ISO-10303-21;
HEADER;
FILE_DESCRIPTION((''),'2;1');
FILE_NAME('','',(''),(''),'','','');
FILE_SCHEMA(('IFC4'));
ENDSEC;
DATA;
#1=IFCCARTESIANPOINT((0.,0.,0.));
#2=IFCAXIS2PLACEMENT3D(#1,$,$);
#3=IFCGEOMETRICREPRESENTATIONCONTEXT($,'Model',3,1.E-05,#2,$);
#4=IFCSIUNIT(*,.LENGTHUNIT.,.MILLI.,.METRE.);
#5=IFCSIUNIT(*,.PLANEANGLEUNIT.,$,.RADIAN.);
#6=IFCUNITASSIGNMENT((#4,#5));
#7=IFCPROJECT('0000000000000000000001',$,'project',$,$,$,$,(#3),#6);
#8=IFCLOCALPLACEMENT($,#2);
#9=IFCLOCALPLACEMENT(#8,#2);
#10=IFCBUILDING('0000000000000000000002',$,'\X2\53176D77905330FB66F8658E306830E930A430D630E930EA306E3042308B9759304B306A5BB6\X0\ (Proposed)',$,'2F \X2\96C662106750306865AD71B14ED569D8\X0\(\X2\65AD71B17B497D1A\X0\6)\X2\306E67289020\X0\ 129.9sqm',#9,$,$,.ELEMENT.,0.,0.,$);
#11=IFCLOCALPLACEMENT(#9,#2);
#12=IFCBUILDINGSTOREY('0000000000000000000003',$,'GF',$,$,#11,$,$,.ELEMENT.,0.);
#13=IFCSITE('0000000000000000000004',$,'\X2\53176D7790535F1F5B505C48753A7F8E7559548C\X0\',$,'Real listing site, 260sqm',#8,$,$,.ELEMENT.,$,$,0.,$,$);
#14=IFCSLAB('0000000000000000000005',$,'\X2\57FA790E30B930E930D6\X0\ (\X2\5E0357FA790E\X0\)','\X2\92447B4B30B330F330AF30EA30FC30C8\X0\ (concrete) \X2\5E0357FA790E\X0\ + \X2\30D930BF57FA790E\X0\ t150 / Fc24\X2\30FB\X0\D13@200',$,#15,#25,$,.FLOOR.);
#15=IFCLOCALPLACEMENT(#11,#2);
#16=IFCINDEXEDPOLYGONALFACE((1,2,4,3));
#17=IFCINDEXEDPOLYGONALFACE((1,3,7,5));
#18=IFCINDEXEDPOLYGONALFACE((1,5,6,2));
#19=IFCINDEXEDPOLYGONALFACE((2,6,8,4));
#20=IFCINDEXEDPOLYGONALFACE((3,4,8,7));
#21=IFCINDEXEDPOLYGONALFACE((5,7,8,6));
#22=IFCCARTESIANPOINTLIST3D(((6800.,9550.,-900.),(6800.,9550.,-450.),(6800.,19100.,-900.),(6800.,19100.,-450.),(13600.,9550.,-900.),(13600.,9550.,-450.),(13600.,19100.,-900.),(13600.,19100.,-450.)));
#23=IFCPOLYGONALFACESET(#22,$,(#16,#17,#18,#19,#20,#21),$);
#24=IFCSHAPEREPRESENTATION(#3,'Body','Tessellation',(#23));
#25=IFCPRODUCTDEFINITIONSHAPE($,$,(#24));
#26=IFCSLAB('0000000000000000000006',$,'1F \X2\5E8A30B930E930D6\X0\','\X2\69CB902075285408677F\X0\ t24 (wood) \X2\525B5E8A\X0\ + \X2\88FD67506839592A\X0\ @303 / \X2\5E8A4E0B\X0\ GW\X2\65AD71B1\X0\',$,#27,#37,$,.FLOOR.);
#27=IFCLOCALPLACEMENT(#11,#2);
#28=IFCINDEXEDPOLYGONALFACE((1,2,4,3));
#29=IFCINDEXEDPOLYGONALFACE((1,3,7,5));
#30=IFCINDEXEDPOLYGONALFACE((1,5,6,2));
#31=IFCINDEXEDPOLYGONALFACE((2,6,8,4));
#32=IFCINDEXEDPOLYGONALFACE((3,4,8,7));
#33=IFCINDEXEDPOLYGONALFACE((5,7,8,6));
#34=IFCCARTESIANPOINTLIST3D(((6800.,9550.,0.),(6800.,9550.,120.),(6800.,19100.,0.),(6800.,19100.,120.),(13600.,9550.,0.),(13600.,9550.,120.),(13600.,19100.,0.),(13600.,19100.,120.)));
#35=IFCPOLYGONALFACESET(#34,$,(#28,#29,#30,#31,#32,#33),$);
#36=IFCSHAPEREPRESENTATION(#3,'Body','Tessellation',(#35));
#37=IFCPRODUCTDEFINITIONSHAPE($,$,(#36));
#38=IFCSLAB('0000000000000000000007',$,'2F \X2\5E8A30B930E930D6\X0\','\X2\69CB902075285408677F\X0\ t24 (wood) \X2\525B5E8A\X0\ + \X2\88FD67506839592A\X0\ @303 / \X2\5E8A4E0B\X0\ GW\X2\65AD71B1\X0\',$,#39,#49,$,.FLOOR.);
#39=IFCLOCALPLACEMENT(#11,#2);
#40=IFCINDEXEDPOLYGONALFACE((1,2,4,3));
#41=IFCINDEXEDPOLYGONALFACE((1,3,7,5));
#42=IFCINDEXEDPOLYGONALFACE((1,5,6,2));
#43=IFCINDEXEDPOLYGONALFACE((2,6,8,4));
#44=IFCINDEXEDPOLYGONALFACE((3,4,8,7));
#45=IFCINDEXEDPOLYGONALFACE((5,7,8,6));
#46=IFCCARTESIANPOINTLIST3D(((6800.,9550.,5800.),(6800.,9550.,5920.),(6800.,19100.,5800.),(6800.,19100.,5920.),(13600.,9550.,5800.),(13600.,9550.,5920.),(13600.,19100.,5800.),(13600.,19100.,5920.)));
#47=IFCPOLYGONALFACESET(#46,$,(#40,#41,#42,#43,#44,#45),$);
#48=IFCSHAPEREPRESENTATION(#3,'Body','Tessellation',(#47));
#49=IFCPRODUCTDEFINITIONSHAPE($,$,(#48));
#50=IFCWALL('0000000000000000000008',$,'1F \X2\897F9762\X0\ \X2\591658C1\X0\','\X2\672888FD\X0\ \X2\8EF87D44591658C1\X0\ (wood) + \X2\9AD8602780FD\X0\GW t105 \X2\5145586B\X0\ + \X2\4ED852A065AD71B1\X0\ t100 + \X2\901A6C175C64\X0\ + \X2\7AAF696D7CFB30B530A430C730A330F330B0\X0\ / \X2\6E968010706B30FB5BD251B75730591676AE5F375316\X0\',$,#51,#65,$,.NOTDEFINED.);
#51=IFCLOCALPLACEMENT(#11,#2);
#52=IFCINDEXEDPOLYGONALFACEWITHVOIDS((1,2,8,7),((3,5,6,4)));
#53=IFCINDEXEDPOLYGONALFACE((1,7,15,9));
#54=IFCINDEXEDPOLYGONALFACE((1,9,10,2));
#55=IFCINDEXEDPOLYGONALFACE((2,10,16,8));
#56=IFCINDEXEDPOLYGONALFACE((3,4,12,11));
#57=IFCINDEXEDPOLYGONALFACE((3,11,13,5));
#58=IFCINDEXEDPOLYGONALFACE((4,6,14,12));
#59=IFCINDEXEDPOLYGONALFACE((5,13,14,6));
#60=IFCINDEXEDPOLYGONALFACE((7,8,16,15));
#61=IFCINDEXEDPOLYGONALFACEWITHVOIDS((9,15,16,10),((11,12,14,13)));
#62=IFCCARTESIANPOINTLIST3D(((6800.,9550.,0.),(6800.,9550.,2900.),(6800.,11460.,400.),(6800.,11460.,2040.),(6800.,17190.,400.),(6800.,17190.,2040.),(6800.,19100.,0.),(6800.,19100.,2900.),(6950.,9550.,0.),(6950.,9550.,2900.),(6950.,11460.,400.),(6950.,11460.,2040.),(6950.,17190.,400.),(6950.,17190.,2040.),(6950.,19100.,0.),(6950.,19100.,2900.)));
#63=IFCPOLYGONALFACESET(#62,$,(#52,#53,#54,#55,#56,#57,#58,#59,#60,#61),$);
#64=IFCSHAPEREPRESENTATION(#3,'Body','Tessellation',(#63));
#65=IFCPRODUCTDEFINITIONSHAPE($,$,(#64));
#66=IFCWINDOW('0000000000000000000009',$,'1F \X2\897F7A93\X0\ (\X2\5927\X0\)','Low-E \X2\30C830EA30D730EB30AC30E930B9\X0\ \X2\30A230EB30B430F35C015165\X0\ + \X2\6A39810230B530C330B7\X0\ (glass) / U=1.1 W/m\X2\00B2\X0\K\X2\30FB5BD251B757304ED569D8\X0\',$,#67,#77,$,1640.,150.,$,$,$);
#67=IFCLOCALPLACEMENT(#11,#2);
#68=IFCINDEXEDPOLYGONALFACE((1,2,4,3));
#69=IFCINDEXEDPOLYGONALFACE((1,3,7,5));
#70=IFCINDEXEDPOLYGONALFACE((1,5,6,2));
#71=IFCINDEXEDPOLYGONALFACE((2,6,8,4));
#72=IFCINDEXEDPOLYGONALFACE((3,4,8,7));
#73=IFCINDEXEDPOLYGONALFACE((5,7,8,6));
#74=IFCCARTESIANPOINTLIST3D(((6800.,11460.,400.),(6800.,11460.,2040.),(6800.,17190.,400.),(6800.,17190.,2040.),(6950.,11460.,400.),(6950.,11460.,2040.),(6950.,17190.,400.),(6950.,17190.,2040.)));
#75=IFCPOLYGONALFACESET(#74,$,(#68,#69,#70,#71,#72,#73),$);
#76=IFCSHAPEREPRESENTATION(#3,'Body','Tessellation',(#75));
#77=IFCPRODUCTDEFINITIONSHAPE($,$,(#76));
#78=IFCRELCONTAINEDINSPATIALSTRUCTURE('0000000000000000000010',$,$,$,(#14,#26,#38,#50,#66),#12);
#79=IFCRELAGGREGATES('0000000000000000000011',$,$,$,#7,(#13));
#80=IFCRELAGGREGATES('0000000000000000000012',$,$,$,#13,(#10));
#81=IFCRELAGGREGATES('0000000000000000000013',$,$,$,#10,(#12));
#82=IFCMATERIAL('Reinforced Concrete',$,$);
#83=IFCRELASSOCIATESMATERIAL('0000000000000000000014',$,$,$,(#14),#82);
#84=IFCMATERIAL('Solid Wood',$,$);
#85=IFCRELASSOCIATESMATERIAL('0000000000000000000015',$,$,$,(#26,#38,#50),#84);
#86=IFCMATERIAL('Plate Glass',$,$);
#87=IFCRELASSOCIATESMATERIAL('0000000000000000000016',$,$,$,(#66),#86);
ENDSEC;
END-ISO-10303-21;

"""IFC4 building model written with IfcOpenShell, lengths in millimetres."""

from ifc_helpers import new_model, si_unit, frame, frame_2d, origin, place, context, project, spatial, rectangle, extrude, material, element, fill, save


model = new_model("IFC4")

# Units and contexts
model_context = context("Model", 3, precision=1e-05, world=origin())
ifc_project = project(units=[si_unit("LENGTHUNIT", "METRE", prefix="MILLI"), si_unit("PLANEANGLEUNIT", "RADIAN")], contexts=[model_context])

# Site, building, storey
site_placement = place(None, origin())
site = spatial("IfcSite", under=ifc_project, at=site_placement, Name="北海道弟子屈町美留和", ObjectType="Real listing site, 260sqm", CompositionType="ELEMENT", RefElevation=0.0)
building_placement = place(site_placement, origin())
building = spatial("IfcBuilding", under=site, at=building_placement, Name="北海道・書斎とライブラリのある静かな家 (Proposed)", ObjectType="2F 集成材と断熱仕様(断熱等級6)の木造 129.9sqm", CompositionType="ELEMENT", ElevationOfRefHeight=0.0, ElevationOfTerrain=0.0)
storey_placement = place(building_placement, origin())
storey = spatial("IfcBuildingStorey", under=building, at=storey_placement, Name="GF", CompositionType="ELEMENT", Elevation=0.0)

# Shared definitions
ifc_material_1 = material(Name="Solid Wood")

# Slabs
ifc_material_2 = material(Name="Reinforced Concrete")
slab_1_placement = place(storey_placement, frame((3400.0, 4775.0, -450.0)))
element("IfcSlab", 1, at=slab_1_placement, inside=storey, material=ifc_material_2, Name="基礎スラブ (布基礎)", Description="鉄筋コンクリート (concrete) 布基礎 + ベタ基礎 t150 / Fc24・D13@200", PredefinedType="FLOOR", context=model_context, shape_type="SweptSolid", body=[
    extrude(rectangle(XDim=6800.0, YDim=9550.0, at=frame_2d((3400.0, 4775.0))), frame((3400.0, 4775.0, -450.0)), (0.0, 0.0, 1.0), 450.0),
])
slab_2_placement = place(storey_placement, frame((3400.0, 4775.0, 0.0)))
element("IfcSlab", 2, at=slab_2_placement, inside=storey, material=ifc_material_1, Name="1F 床スラブ", Description="構造用合板 t24 (wood) 剛床 + 製材根太 @303 / 床下 GW断熱", PredefinedType="FLOOR", context=model_context, shape_type="SweptSolid", body=[
    extrude(rectangle(XDim=6800.0, YDim=9550.0, at=frame_2d((3400.0, 4775.0))), frame((3400.0, 4775.0, 0.0)), (0.0, 0.0, 1.0), 120.0),
])
slab_3_placement = place(storey_placement, frame((3400.0, 4775.0, 2900.0)))
element("IfcSlab", 3, at=slab_3_placement, inside=storey, material=ifc_material_1, Name="2F 床スラブ", Description="構造用合板 t24 (wood) 剛床 + 製材根太 @303 / 床下 GW断熱", PredefinedType="FLOOR", context=model_context, shape_type="SweptSolid", body=[
    extrude(rectangle(XDim=6800.0, YDim=9550.0, at=frame_2d((3400.0, 4775.0))), frame((3400.0, 4775.0, 2900.0)), (0.0, 0.0, 1.0), 120.0),
])

# Shared definitions
ifc_material_3 = material(Name="Plate Glass")

# Wall, opening, window
wall_1_placement = place(storey_placement, frame((3400.0, 4775.0, 0.0)))
wall_1 = element("IfcWall", 4, at=wall_1_placement, inside=storey, material=ifc_material_1, Name="1F 西面 外壁", Description="木製 軸組外壁 (wood) + 高性能GW t105 充填 + 付加断熱 t100 + 通気層 + 窯業系サイディング / 準耐火・寒冷地外皮強化", PredefinedType="NOTDEFINED", context=model_context, shape_type="SweptSolid", body=[
    extrude(rectangle(XDim=150.0, YDim=9550.0, at=frame_2d((75.0, 4775.0))), frame((3400.0, 4775.0, 0.0)), (0.0, 0.0, 1.0), 2900.0),
])
opening_1_placement = place(storey_placement, frame((3400.0, 5730.0, 200.0)))
opening_1 = element("IfcOpeningElement", 5, at=opening_1_placement, cuts=wall_1, PredefinedType="NOTDEFINED", context=model_context, shape_type="SweptSolid", body=[
    extrude(rectangle(XDim=150.0, YDim=5730.0, at=frame_2d((75.0, 2865.0))), frame((3400.0, 5730.0, 200.0)), (0.0, 0.0, 1.0), 1640.0),
])
window_1_placement = place(storey_placement, frame((3400.0, 5730.0, 200.0)))
window_1 = element("IfcWindow", 6, at=window_1_placement, inside=storey, material=ifc_material_3, Name="1F 西窓 (大)", Description="Low-E トリプルガラス アルゴン封入 + 樹脂サッシ (glass) / U=1.1 W/m²K・寒冷地仕様", OverallHeight=1640.0, OverallWidth=150.0, context=model_context, shape_type="SweptSolid", body=[
    extrude(rectangle(XDim=150.0, YDim=5730.0, at=frame_2d((75.0, 2865.0))), frame((3400.0, 5730.0, 200.0)), (0.0, 0.0, 1.0), 1640.0),
])
fill(opening_1, window_1)

save(model, "model.ifc")
